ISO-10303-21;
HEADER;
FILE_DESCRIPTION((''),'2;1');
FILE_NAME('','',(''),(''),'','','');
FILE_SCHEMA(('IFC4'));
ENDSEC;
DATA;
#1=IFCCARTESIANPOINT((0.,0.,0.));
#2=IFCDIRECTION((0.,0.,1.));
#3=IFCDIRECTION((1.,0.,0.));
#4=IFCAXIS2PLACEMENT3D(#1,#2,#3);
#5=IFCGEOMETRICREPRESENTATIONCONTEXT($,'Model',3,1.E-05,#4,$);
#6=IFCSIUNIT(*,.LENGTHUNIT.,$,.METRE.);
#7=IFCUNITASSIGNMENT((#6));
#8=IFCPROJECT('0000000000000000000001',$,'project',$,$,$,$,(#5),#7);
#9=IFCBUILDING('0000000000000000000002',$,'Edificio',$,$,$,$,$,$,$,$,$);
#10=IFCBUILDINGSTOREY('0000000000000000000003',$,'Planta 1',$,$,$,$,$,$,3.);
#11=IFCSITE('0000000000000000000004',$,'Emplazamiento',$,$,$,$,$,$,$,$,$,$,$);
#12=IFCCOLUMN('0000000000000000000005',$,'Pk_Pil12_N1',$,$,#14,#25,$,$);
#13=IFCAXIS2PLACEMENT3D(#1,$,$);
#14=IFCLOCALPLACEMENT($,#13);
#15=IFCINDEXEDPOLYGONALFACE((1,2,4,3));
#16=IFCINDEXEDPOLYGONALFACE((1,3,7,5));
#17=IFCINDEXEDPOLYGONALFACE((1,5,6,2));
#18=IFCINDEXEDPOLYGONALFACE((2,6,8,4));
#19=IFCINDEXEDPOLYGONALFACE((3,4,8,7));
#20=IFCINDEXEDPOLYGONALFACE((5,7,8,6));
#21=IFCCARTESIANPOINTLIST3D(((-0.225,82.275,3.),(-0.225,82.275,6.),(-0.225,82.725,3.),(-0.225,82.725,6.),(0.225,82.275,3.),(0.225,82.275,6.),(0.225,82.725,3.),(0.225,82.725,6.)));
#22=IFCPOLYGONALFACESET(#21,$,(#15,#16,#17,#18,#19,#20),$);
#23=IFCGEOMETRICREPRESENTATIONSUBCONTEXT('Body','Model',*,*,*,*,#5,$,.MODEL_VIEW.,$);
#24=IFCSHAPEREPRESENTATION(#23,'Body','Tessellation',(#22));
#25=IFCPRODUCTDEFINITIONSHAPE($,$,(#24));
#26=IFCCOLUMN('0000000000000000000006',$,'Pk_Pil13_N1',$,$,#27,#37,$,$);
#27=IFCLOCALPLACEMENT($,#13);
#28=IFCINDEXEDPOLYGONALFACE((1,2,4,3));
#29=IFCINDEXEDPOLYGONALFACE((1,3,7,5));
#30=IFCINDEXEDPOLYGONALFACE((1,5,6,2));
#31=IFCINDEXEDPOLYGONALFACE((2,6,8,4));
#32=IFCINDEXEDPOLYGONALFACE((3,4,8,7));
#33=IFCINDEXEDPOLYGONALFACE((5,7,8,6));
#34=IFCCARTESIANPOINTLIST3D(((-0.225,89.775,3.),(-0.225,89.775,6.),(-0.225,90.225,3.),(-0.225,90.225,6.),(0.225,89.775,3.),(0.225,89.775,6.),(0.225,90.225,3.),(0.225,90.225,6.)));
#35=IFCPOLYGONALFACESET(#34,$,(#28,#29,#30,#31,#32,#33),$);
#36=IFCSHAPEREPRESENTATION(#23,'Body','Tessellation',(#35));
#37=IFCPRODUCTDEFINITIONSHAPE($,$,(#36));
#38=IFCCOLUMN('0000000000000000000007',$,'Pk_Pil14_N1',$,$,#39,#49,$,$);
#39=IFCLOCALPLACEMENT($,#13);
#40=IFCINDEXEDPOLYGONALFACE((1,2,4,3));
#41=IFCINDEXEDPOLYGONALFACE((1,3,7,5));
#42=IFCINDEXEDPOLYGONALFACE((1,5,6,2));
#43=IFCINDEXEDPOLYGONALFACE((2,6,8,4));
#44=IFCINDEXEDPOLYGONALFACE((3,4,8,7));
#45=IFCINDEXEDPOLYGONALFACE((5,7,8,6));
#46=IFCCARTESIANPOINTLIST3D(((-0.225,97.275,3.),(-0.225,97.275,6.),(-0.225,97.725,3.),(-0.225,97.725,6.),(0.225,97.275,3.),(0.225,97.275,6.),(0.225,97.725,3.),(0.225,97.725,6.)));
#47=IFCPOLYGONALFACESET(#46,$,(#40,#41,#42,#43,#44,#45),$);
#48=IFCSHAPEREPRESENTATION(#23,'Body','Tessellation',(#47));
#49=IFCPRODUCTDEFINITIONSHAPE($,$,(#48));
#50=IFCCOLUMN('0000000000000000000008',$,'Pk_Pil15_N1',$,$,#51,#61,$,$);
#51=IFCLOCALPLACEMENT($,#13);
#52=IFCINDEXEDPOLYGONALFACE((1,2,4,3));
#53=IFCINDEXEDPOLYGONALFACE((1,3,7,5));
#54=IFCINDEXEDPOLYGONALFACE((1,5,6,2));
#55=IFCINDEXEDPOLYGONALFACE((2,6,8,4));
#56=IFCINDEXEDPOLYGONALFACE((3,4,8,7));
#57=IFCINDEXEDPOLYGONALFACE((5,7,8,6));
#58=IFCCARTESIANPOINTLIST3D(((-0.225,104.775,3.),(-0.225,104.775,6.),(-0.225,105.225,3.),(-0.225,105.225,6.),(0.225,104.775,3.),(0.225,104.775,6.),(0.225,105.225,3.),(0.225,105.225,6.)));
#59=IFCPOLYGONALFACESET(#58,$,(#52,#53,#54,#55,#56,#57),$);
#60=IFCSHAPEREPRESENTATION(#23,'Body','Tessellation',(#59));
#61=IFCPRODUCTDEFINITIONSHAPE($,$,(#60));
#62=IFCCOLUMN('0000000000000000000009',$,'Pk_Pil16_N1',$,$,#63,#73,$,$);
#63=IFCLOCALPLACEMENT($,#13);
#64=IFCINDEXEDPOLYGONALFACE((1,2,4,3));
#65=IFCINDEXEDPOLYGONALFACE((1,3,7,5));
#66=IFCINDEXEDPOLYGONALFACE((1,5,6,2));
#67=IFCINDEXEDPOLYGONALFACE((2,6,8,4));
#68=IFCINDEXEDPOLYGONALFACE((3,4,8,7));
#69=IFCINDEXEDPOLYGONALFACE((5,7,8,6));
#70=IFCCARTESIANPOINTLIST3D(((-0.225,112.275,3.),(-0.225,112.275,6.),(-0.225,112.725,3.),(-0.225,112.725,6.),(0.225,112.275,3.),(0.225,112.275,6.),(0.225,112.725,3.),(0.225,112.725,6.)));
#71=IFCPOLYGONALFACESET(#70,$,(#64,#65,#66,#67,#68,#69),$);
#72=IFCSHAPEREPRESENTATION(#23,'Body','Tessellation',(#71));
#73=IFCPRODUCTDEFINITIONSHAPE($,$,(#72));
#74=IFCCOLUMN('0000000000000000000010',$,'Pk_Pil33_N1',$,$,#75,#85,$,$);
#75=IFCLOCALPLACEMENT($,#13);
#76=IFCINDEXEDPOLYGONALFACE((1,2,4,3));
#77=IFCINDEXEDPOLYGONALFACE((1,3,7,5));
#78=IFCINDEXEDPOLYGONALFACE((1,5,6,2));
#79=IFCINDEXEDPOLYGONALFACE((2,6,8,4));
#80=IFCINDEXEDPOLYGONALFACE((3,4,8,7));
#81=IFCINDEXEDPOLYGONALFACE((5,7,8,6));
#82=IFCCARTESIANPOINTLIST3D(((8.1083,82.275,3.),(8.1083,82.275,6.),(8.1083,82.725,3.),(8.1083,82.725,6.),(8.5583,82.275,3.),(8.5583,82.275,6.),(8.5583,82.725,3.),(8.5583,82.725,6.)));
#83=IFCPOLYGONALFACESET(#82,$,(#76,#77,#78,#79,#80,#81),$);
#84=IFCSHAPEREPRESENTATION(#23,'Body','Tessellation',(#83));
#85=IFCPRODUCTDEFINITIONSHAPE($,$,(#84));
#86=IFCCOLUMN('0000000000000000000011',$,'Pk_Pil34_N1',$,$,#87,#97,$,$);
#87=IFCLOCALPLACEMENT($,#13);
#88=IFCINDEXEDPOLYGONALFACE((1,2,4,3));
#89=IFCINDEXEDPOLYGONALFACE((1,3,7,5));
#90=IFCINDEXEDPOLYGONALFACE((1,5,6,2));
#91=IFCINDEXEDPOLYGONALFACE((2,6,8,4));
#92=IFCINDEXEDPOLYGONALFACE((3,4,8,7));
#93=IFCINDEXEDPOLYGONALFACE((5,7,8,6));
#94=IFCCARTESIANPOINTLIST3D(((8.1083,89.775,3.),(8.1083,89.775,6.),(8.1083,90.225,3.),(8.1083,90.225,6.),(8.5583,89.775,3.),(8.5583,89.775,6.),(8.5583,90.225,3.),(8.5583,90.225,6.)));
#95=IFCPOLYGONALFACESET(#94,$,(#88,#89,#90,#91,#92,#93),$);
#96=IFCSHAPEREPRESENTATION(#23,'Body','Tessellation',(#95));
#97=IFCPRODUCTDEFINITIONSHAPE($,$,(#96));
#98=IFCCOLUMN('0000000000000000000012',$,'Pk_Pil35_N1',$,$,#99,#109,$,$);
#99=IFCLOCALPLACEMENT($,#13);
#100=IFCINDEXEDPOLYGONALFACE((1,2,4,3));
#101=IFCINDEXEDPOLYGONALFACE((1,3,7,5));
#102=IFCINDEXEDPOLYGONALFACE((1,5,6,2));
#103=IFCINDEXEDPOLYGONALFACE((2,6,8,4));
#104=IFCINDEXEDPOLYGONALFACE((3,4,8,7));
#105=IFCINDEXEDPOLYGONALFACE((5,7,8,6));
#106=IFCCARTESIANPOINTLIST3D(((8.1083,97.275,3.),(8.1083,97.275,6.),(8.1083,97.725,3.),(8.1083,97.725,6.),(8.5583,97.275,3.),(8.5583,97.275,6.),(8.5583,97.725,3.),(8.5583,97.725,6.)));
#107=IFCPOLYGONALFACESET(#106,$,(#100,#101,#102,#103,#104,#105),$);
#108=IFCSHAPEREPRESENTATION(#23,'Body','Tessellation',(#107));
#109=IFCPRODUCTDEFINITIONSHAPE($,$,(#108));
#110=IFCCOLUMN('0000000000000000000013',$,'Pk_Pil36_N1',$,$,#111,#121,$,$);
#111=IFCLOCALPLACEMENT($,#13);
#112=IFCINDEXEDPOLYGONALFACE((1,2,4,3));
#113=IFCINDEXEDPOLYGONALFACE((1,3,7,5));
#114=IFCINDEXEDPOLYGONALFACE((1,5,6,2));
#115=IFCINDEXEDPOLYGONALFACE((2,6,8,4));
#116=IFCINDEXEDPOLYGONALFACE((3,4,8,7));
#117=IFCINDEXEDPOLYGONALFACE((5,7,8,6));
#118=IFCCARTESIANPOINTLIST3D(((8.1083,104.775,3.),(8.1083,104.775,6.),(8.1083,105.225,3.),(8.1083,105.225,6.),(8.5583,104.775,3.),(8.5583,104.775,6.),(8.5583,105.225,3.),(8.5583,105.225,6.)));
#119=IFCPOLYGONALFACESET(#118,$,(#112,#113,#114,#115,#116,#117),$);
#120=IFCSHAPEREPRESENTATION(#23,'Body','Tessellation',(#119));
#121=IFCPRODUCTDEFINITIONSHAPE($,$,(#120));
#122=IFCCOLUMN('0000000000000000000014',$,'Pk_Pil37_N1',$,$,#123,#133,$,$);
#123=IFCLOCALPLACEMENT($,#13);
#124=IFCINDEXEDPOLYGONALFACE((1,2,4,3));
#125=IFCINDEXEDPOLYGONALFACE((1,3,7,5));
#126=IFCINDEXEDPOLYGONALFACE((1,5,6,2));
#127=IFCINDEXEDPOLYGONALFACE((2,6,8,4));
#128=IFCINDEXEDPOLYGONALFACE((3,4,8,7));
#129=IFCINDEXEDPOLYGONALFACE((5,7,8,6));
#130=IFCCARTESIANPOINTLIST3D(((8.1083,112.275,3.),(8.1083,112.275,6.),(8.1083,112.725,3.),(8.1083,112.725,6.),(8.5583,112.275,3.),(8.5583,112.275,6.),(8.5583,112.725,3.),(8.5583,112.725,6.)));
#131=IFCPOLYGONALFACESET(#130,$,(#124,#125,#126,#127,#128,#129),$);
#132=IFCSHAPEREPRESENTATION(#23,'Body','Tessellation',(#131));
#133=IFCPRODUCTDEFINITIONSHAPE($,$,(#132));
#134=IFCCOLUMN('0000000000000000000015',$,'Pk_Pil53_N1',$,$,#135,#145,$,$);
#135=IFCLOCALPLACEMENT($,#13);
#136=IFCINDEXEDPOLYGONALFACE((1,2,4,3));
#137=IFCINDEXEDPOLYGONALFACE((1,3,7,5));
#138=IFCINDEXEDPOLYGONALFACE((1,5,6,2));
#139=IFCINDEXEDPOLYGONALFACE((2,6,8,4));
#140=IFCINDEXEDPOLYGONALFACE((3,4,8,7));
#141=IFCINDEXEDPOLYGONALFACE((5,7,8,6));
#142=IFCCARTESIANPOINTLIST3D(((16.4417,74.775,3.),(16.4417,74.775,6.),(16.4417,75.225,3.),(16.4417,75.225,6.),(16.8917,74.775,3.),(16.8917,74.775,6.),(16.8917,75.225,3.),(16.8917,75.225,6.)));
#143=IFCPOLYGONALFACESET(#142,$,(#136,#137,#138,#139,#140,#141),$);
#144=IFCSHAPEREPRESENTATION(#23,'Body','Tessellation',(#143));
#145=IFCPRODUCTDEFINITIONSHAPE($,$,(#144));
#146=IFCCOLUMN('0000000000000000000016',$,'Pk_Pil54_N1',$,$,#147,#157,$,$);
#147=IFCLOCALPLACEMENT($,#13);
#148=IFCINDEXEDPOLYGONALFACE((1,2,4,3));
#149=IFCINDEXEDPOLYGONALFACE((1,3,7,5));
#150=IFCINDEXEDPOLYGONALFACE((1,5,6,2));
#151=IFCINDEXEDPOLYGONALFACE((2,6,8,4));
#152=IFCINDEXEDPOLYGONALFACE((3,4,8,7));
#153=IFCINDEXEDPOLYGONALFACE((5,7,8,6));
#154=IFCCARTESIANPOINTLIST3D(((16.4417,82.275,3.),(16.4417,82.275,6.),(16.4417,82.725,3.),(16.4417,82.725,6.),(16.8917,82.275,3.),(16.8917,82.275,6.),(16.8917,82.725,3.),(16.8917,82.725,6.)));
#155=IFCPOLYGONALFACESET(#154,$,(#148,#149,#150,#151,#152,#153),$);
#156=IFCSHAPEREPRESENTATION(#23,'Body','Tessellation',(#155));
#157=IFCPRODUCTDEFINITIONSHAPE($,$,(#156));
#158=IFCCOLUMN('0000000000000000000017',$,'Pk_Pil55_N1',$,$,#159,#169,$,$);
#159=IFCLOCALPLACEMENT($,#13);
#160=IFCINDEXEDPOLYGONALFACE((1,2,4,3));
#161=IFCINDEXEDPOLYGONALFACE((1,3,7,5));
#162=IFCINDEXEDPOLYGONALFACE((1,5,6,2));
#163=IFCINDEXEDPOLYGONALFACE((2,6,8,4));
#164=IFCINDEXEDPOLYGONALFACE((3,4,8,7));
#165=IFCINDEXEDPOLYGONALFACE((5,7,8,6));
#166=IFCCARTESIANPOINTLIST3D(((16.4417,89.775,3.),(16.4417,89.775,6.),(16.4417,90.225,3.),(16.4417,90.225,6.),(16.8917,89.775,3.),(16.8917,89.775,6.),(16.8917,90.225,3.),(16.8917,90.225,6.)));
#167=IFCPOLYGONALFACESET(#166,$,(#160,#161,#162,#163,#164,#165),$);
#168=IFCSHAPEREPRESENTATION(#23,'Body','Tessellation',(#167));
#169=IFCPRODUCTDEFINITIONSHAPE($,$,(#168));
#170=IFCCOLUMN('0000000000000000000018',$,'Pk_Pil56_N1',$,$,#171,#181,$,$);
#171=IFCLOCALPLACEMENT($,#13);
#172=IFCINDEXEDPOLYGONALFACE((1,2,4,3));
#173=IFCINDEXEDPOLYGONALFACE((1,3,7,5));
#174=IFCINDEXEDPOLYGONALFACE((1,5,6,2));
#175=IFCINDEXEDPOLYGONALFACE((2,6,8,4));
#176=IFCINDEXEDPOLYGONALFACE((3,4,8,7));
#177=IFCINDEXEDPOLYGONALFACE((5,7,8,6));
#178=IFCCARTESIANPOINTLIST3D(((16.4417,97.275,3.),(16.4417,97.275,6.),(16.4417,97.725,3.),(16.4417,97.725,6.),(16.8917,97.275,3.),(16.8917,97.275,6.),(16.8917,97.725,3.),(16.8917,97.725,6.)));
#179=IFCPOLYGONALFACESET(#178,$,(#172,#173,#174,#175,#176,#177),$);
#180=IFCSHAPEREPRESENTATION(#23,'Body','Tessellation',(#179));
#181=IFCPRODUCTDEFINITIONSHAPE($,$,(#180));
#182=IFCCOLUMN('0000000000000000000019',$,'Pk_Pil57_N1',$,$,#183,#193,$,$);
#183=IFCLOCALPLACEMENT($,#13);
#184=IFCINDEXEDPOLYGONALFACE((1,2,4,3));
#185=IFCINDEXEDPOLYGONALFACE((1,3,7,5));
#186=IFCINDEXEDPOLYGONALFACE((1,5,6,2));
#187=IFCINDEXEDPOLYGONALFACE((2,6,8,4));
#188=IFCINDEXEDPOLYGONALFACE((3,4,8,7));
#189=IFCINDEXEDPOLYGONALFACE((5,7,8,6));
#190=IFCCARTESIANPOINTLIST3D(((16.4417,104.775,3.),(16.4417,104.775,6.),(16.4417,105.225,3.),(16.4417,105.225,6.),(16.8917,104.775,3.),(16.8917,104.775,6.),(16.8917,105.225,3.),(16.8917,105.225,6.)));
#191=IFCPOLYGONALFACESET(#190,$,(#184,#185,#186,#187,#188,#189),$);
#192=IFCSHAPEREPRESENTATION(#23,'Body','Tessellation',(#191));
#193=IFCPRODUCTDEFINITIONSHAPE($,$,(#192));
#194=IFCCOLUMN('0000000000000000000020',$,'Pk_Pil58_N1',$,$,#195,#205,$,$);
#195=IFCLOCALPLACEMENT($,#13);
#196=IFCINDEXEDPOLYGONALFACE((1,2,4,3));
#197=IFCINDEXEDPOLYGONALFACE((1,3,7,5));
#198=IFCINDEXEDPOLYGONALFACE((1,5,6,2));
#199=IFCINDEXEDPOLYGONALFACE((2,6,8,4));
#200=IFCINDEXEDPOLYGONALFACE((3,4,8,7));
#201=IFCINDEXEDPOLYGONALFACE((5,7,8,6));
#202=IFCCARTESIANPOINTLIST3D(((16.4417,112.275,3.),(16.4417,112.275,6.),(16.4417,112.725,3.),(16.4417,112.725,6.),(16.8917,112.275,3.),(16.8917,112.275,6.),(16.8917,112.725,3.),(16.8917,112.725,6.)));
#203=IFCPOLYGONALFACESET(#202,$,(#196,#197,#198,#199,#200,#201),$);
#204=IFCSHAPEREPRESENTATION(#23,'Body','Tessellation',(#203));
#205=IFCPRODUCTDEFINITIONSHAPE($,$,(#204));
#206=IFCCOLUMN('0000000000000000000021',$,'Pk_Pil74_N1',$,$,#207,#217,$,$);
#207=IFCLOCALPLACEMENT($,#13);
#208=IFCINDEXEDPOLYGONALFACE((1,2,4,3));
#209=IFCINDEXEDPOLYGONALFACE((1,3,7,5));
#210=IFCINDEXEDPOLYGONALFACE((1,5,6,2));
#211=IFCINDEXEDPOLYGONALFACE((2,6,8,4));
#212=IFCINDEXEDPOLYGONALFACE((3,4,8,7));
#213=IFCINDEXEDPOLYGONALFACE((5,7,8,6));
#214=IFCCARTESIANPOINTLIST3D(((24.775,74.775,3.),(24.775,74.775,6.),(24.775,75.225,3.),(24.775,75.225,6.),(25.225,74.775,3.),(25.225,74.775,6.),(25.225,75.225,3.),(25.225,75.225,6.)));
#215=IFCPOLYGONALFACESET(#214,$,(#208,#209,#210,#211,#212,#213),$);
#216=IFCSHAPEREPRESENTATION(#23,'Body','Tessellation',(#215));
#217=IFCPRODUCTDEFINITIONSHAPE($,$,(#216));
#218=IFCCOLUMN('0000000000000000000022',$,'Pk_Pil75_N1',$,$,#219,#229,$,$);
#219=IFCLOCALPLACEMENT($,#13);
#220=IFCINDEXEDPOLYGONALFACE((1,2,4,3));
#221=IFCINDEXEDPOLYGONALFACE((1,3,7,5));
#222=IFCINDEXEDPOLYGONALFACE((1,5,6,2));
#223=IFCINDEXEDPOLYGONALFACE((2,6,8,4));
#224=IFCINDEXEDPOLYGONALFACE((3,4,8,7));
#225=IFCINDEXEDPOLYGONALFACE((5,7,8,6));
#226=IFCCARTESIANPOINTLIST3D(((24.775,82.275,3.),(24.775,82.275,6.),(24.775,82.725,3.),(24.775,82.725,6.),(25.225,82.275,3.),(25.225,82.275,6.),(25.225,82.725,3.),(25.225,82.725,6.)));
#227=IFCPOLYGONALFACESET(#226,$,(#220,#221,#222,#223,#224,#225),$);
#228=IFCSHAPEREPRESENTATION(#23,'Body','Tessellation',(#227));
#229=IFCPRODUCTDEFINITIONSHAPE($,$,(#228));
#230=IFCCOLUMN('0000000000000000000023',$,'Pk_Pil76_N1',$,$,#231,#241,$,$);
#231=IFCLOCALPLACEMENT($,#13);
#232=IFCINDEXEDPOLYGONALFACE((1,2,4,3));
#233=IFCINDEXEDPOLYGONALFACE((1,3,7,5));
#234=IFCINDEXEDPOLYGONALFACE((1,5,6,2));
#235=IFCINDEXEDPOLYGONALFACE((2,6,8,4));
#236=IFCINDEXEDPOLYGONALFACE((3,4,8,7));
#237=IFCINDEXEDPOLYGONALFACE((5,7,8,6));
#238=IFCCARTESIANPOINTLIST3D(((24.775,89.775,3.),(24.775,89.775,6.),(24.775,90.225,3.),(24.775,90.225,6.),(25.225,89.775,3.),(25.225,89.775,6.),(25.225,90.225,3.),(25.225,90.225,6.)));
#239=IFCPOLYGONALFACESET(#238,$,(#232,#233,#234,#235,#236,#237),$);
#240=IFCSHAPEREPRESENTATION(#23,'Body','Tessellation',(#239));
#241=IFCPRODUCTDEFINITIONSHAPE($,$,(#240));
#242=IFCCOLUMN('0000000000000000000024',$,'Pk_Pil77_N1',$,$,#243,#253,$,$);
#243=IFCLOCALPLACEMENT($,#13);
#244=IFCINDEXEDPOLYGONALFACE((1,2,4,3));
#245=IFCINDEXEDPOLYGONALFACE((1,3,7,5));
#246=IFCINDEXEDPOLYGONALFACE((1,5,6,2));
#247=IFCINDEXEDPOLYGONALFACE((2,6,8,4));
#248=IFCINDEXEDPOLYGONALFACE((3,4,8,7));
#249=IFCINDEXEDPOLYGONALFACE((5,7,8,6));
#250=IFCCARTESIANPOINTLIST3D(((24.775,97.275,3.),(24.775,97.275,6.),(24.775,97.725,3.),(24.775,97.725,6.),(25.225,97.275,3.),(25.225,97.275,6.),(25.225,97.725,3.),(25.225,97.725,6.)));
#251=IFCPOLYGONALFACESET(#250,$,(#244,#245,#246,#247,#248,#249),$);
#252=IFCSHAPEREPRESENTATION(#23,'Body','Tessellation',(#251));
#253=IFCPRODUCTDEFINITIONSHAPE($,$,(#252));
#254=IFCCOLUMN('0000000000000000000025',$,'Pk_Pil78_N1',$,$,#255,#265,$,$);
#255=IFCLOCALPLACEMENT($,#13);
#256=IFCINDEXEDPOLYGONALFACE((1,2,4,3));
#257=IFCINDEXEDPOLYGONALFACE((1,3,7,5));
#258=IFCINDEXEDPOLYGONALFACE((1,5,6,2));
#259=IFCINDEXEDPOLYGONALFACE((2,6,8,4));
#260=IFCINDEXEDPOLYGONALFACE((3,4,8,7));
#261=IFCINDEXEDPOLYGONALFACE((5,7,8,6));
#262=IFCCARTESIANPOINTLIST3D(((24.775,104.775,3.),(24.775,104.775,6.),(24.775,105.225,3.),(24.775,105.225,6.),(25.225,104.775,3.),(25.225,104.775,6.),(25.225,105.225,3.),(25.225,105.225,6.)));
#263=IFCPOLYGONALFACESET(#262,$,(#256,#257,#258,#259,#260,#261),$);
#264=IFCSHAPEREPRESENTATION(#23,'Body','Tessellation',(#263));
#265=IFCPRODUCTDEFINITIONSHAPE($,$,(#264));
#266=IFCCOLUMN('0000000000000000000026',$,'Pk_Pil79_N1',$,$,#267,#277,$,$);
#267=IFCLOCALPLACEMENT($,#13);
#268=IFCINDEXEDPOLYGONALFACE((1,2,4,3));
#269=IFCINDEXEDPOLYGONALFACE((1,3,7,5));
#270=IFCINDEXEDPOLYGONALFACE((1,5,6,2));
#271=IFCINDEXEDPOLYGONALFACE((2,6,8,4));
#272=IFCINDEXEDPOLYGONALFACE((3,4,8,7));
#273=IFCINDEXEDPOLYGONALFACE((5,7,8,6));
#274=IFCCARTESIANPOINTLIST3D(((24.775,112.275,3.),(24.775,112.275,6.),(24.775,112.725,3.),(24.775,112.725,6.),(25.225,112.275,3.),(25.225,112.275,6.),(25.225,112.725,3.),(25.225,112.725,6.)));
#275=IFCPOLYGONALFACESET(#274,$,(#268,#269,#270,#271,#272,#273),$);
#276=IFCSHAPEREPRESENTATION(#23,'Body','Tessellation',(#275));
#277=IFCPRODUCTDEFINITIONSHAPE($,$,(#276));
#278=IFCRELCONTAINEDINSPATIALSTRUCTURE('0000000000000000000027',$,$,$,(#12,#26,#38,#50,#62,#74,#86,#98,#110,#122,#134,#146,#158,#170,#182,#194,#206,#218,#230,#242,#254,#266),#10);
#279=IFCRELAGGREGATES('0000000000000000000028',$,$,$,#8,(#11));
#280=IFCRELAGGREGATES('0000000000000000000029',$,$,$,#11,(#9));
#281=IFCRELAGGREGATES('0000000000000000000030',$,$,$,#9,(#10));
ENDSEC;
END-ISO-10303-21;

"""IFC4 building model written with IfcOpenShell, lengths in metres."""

from ifc_helpers import new_model, si_unit, frame, origin_with_axes, origin_2d, place, context, subcontext, project, spatial, rectangle, extrude, element, save


model = new_model("IFC4")

# Units and contexts
model_context = context("Model", 3, precision=1e-05, world=origin_with_axes())
body_context = subcontext(model_context, "Body", "Model", "MODEL_VIEW")
ifc_project = project(units=[si_unit("LENGTHUNIT", "METRE")], contexts=[model_context])

# Site, building, storey
site = spatial("IfcSite", under=ifc_project, Name="Emplazamiento")
building = spatial("IfcBuilding", under=site, Name="Edificio")
storey = spatial("IfcBuildingStorey", under=building, Name="Planta 1", Elevation=3.0)

# Columns
for number, where, z_axis, x_axis, name in (
    (1, (0.0, 82.5, 3.0), (0.0, 0.0, 1.0), (1.0, 0.0, 0.0), "Pk_Pil12_N1"),
    (2, (0.0, 90.0, 3.0), (0.0, 0.0, 1.0), (1.0, 0.0, 0.0), "Pk_Pil13_N1"),
    (3, (0.0, 97.5, 3.0), (0.0, 0.0, 1.0), (1.0, 0.0, 0.0), "Pk_Pil14_N1"),
    (4, (0.0, 105.0, 3.0), (0.0, 0.0, 1.0), (1.0, 0.0, 0.0), "Pk_Pil15_N1"),
    (5, (0.0, 112.5, 3.0), (0.0, 0.0, 1.0), (1.0, 0.0, 0.0), "Pk_Pil16_N1"),
    (6, (8.3333, 82.5, 3.0), (0.0, 0.0, 1.0), (1.0, 0.0, 0.0), "Pk_Pil33_N1"),
    (7, (8.3333, 90.0, 3.0), (0.0, 0.0, 1.0), (1.0, 0.0, 0.0), "Pk_Pil34_N1"),
    (8, (8.3333, 97.5, 3.0), (0.0, 0.0, 1.0), (1.0, 0.0, 0.0), "Pk_Pil35_N1"),
    (9, (8.3333, 105.0, 3.0), (0.0, 0.0, 1.0), (1.0, 0.0, 0.0), "Pk_Pil36_N1"),
    (10, (8.3333, 112.5, 3.0), (0.0, 0.0, 1.0), (1.0, 0.0, 0.0), "Pk_Pil37_N1"),
    (11, (16.6667, 75.0, 3.0), (0.0, 0.0, 1.0), (1.0, 0.0, 0.0), "Pk_Pil53_N1"),
    (12, (16.6667, 82.5, 3.0), (0.0, 0.0, 1.0), (1.0, 0.0, 0.0), "Pk_Pil54_N1"),
    (13, (16.6667, 90.0, 3.0), (0.0, 0.0, 1.0), (1.0, 0.0, 0.0), "Pk_Pil55_N1"),
    (14, (16.6667, 97.5, 3.0), (0.0, 0.0, 1.0), (1.0, 0.0, 0.0), "Pk_Pil56_N1"),
    (15, (16.6667, 105.0, 3.0), (0.0, 0.0, 1.0), (1.0, 0.0, 0.0), "Pk_Pil57_N1"),
    (16, (16.6667, 112.5, 3.0), (0.0, 0.0, 1.0), (1.0, 0.0, 0.0), "Pk_Pil58_N1"),
    (17, (25.0, 75.0, 3.0), (0.0, 0.0, 1.0), (1.0, 0.0, 0.0), "Pk_Pil74_N1"),
    (18, (25.0, 82.5, 3.0), (0.0, 0.0, 1.0), (1.0, 0.0, 0.0), "Pk_Pil75_N1"),
    (19, (25.0, 90.0, 3.0), (0.0, 0.0, 1.0), (1.0, 0.0, 0.0), "Pk_Pil76_N1"),
    (20, (25.0, 97.5, 3.0), (0.0, 0.0, 1.0), (1.0, 0.0, 0.0), "Pk_Pil77_N1"),
    (21, (25.0, 105.0, 3.0), (0.0, 0.0, 1.0), (1.0, 0.0, 0.0), "Pk_Pil78_N1"),
    (22, (25.0, 112.5, 3.0), (0.0, 0.0, 1.0), (1.0, 0.0, 0.0), "Pk_Pil79_N1"),
):
    element("IfcColumn", number, at=place(None, frame(where, z_axis=z_axis, x_axis=x_axis)), inside=storey, Name=name, context=body_context, shape_type="SweptSolid", body=[
        extrude(rectangle(XDim=0.45, YDim=0.45, at=origin_2d()), origin_with_axes(), (0.0, 0.0, 1.0), 3.0),
    ])

save(model, "model.ifc")
